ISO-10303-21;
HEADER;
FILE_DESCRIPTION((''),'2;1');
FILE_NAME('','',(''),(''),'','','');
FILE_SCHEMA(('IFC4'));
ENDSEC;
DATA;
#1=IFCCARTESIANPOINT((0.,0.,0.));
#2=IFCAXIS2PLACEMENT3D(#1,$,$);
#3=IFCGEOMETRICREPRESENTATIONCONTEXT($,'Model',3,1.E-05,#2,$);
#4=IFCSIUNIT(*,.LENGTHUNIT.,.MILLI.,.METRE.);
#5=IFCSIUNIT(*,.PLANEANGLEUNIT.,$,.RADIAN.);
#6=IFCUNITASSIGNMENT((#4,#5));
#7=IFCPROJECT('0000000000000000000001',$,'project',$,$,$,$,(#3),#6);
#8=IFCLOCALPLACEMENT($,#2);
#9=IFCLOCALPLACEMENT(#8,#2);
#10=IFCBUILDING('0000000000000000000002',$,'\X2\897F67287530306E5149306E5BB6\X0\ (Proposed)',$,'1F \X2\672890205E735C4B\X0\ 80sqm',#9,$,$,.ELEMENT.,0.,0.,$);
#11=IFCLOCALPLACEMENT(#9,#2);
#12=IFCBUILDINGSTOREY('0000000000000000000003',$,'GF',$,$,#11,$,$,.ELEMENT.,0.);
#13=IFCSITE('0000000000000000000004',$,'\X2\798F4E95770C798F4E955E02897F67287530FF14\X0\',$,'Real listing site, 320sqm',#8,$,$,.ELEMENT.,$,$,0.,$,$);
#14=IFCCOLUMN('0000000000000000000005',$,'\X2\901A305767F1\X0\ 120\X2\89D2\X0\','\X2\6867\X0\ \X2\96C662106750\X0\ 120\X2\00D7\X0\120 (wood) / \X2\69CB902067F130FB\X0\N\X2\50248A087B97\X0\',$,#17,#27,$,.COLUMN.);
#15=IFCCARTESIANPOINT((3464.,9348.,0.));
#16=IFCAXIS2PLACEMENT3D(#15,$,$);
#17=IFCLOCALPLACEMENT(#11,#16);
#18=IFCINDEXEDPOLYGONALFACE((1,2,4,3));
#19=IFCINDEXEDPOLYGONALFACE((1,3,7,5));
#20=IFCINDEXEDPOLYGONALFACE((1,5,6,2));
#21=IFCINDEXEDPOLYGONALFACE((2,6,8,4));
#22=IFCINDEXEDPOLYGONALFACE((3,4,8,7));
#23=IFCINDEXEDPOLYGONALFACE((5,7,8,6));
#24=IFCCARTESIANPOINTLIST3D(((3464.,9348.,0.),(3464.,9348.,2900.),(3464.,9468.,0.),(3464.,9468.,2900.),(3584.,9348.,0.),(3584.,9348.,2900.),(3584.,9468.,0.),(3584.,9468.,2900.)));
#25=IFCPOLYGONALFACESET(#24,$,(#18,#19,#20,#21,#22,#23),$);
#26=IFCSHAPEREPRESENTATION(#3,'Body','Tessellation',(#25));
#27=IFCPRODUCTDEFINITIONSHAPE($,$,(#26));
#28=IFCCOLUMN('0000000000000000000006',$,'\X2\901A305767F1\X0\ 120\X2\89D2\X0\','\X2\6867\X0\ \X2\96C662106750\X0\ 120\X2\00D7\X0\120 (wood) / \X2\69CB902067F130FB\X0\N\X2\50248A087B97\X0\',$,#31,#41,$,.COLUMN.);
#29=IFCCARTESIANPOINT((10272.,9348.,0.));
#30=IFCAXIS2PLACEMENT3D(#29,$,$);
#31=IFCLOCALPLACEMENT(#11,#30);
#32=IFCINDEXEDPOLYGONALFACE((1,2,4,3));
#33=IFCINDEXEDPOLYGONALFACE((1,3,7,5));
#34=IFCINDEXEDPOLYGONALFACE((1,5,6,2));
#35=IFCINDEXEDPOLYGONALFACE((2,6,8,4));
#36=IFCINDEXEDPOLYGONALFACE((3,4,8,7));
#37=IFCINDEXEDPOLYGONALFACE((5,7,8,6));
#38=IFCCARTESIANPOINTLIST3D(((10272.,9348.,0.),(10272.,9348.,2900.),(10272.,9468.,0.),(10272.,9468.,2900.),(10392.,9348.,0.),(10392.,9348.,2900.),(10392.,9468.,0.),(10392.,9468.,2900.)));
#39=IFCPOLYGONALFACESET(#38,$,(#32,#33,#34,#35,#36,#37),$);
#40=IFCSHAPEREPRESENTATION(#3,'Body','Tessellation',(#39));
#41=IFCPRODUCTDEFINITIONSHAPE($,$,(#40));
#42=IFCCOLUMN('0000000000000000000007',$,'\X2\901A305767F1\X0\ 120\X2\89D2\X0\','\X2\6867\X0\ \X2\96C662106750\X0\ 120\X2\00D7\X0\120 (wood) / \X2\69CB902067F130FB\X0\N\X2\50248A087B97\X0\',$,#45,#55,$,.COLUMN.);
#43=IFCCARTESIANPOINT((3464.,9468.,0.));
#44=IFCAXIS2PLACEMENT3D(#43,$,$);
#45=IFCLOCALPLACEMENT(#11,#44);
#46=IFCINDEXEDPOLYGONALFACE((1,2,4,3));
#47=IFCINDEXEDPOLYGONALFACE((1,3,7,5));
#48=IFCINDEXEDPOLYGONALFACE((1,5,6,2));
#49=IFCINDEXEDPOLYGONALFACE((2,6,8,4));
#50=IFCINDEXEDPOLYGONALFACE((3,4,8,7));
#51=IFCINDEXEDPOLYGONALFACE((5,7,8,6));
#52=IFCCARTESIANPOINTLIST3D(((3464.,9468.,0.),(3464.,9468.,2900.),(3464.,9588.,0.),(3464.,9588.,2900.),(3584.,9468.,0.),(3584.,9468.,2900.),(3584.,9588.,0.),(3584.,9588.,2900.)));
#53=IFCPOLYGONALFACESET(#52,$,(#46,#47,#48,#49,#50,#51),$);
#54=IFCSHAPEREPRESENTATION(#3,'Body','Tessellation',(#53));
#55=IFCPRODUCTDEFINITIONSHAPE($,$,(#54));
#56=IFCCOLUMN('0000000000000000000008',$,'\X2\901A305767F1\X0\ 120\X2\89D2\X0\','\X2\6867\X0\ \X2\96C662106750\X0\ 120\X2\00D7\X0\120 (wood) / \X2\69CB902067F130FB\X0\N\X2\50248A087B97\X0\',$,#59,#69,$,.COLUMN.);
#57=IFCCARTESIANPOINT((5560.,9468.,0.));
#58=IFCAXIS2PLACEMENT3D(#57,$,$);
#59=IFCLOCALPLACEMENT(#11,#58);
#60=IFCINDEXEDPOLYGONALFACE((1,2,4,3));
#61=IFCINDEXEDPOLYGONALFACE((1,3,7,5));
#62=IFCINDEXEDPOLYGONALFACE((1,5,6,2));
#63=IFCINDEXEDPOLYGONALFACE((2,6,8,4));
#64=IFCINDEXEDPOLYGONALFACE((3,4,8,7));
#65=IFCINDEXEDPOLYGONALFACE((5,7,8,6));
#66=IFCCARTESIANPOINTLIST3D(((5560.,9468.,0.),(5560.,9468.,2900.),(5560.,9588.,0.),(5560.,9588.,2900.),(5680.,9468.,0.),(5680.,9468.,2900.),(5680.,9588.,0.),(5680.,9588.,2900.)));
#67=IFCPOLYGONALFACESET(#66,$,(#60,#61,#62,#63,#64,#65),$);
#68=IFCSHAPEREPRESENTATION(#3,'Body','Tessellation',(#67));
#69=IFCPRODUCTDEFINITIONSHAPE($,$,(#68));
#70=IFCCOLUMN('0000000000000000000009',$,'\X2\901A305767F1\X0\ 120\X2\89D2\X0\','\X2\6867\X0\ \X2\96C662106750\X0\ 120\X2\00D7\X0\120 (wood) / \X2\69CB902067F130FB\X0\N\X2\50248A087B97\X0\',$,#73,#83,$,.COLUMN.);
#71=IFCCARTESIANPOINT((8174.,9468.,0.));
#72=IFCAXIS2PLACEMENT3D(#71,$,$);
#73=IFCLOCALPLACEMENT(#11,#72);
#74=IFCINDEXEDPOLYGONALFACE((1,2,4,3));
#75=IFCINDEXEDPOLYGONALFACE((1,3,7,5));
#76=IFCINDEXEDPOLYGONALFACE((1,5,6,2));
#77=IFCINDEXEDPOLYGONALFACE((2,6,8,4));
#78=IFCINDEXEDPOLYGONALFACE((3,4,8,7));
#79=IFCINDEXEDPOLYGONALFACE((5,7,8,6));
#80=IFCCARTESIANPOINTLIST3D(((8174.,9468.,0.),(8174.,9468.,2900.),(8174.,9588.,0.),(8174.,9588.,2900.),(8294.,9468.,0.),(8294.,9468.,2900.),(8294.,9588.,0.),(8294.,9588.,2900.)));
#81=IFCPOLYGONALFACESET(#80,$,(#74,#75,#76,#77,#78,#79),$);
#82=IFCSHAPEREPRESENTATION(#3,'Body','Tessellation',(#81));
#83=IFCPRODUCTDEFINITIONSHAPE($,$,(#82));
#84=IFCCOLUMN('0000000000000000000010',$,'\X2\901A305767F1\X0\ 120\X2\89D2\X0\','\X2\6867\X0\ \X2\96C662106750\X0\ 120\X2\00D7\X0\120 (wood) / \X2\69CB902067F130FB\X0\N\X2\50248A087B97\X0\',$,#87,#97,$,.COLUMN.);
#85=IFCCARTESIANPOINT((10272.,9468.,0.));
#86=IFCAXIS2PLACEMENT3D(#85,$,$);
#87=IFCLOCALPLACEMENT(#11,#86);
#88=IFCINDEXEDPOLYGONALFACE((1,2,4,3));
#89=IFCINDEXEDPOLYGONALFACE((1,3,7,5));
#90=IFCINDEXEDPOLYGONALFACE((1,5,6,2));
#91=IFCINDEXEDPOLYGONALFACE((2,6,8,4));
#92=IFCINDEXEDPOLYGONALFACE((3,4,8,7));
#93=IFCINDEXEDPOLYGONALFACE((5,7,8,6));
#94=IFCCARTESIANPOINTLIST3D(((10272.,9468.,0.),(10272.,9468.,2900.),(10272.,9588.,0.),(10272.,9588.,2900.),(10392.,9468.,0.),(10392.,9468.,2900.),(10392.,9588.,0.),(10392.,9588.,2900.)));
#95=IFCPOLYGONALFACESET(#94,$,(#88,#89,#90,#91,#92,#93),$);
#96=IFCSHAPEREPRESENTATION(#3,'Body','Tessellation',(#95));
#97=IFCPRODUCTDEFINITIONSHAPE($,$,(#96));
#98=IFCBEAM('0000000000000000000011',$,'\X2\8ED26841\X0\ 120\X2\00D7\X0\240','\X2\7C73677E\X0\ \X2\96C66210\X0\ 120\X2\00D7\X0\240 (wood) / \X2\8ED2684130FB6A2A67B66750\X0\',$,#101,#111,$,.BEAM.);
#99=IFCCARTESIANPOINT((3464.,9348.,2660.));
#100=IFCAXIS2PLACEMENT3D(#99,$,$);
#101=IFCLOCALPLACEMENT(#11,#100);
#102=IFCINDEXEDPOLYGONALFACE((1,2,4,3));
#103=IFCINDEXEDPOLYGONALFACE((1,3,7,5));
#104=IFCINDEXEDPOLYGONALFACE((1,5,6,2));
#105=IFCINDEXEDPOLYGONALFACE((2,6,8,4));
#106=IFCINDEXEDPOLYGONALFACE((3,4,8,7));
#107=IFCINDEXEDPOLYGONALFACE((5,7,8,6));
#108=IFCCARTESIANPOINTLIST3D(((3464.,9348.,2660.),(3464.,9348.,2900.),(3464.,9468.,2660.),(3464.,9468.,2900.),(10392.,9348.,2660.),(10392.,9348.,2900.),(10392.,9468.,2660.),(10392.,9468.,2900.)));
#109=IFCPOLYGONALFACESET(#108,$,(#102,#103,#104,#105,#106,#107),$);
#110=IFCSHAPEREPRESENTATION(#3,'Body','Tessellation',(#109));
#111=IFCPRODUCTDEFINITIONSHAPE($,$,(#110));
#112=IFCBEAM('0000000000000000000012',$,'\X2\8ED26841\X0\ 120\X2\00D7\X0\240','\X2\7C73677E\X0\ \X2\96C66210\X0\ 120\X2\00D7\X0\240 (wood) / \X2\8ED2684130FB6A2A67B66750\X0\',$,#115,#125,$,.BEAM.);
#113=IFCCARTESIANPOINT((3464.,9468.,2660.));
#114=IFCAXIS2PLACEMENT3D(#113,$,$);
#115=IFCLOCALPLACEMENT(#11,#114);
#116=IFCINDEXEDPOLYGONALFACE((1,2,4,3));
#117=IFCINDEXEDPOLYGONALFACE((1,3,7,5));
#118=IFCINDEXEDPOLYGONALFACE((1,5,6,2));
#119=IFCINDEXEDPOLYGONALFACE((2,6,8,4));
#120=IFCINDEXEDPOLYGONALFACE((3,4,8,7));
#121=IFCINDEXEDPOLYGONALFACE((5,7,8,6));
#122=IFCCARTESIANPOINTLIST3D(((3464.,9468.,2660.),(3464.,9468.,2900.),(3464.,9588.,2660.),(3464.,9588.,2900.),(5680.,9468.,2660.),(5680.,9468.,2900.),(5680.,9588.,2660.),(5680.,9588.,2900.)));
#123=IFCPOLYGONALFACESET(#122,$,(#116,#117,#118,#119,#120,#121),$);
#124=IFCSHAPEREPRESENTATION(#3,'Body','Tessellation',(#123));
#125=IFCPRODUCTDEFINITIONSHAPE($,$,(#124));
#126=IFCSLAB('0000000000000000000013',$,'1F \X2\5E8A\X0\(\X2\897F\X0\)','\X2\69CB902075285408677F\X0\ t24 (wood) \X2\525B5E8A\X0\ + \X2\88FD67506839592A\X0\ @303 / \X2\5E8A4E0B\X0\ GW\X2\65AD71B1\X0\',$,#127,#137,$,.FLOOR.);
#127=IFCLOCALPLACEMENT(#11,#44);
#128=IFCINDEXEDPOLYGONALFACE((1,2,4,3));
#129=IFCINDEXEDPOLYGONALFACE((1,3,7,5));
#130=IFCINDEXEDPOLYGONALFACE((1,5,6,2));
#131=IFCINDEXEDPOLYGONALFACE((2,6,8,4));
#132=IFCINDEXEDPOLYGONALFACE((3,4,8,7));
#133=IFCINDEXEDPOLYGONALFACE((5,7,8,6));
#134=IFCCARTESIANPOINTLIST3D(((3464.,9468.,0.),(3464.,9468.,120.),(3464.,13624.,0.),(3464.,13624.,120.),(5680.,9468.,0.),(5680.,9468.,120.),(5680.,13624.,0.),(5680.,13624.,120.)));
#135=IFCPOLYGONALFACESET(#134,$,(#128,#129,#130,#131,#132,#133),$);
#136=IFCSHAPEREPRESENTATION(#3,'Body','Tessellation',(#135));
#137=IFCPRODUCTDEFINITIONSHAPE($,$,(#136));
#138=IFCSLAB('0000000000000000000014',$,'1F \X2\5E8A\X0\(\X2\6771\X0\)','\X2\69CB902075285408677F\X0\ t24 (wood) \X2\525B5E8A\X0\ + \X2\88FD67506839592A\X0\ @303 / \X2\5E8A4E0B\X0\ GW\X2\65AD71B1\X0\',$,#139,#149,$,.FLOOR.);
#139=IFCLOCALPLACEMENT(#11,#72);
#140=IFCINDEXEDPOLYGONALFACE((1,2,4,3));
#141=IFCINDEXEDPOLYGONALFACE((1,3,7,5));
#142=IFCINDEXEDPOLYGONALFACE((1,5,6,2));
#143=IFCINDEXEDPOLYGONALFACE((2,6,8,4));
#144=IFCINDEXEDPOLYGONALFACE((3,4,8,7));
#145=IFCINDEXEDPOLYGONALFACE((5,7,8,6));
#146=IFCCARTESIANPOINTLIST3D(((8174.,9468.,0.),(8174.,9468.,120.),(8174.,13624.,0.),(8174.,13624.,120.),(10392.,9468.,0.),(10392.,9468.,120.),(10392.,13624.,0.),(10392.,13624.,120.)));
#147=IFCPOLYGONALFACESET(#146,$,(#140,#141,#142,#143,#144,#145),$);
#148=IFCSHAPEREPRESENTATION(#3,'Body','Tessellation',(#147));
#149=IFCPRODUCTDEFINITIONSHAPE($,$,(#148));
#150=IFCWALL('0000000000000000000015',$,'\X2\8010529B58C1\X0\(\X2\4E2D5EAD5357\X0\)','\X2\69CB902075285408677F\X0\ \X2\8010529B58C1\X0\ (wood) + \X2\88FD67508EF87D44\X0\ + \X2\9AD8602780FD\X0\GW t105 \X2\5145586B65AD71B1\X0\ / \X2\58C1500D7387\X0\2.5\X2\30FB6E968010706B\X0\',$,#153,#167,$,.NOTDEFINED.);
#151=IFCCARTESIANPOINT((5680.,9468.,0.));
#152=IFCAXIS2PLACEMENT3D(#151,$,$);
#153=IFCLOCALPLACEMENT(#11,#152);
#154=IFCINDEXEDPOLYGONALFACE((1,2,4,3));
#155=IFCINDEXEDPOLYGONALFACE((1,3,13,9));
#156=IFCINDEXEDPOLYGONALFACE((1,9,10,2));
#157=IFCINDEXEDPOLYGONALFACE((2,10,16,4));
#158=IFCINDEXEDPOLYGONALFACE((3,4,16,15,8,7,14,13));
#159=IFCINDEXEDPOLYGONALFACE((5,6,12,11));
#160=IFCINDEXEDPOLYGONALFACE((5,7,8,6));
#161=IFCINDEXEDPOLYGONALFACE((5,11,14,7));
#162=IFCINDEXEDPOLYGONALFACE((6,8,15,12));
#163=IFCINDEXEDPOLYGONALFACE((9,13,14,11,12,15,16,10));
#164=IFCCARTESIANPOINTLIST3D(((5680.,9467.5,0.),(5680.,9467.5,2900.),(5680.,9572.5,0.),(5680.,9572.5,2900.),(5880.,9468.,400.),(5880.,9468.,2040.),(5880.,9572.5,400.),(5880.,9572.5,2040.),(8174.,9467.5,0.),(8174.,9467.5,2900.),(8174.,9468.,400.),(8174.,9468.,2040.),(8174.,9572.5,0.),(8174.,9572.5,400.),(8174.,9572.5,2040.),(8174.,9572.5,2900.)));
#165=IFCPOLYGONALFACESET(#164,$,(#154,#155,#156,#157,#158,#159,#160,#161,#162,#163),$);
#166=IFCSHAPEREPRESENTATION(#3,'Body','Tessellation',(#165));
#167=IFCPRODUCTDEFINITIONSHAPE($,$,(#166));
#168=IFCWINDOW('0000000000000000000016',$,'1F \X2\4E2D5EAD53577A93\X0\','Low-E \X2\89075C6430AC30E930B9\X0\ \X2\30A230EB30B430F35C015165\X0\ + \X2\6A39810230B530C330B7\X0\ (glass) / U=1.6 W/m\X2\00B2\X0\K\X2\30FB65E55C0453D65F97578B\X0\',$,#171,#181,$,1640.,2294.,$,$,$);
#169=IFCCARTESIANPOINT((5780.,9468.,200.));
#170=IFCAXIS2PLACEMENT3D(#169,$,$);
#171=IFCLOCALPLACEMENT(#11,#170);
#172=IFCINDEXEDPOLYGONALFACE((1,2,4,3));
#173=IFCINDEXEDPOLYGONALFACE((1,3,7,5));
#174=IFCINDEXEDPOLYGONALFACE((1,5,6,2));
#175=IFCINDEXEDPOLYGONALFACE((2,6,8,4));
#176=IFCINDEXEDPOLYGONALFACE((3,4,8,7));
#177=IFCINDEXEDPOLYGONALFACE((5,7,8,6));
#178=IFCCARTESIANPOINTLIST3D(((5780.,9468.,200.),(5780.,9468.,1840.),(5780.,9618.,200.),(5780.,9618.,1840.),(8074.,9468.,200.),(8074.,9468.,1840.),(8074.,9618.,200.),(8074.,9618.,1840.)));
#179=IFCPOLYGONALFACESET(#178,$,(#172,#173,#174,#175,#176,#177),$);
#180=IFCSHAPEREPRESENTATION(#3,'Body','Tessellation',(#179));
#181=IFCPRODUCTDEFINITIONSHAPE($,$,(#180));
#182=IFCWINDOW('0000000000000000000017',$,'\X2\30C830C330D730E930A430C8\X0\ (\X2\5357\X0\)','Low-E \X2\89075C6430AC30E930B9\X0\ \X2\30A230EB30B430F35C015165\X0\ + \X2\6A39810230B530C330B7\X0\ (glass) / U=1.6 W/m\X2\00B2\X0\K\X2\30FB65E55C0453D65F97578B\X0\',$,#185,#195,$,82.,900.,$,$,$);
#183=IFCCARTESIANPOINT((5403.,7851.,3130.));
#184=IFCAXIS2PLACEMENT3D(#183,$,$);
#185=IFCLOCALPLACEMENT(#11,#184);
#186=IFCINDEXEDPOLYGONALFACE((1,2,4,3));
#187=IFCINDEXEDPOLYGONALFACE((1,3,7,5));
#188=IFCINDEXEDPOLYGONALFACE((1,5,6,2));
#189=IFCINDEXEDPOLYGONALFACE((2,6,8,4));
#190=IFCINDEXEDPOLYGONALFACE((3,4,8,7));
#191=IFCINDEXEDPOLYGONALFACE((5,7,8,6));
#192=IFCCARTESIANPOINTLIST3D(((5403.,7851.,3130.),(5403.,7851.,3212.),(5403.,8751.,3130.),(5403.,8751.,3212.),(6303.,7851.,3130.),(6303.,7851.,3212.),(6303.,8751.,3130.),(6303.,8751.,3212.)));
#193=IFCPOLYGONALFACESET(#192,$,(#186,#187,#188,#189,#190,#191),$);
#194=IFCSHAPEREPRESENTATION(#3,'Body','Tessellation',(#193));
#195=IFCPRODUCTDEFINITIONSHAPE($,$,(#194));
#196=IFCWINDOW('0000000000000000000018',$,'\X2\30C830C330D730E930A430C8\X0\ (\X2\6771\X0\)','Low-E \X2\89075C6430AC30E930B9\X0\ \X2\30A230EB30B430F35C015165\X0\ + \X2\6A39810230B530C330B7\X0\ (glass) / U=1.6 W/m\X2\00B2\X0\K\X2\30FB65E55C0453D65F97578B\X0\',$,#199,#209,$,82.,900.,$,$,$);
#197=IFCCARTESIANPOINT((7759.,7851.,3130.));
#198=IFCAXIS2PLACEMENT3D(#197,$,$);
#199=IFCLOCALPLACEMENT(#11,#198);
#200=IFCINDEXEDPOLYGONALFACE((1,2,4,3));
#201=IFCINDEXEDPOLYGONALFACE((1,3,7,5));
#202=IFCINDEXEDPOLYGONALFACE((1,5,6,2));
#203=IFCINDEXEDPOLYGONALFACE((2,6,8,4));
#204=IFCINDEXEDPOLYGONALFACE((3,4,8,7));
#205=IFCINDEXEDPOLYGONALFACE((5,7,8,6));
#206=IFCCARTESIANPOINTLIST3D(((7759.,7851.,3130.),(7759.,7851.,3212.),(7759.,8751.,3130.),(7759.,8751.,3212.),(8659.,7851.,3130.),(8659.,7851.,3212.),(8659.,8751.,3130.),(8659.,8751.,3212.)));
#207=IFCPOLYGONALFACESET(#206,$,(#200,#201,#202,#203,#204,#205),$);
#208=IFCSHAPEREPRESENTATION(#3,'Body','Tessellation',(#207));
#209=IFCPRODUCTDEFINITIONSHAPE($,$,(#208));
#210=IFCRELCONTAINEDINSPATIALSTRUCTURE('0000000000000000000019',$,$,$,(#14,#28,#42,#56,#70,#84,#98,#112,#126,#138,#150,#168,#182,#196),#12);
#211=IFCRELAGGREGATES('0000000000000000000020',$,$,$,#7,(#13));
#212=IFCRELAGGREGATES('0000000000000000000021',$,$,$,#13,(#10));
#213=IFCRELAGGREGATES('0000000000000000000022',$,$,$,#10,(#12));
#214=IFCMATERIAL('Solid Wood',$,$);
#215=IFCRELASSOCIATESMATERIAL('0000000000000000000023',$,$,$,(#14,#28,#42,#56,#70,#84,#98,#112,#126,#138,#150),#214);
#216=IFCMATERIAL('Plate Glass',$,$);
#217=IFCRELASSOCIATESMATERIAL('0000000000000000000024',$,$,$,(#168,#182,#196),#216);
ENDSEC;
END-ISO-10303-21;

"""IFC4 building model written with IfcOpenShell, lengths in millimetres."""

from ifc_helpers import new_model, si_unit, frame, frame_2d, origin, place, context, project, spatial, rectangle, extrude, material, element, fill, save


model = new_model("IFC4")

# Units and contexts
model_context = context("Model", 3, precision=1e-05, world=origin())
ifc_project = project(units=[si_unit("LENGTHUNIT", "METRE", prefix="MILLI"), si_unit("PLANEANGLEUNIT", "RADIAN")], contexts=[model_context])

# Site, building, storey
site_placement = place(None, origin())
site = spatial("IfcSite", under=ifc_project, at=site_placement, Name="福井県福井市西木田４", ObjectType="Real listing site, 320sqm", CompositionType="ELEMENT", RefElevation=0.0)
building_placement = place(site_placement, origin())
building = spatial("IfcBuilding", under=site, at=building_placement, Name="西木田の光の家 (Proposed)", ObjectType="1F 木造平屋 80sqm", CompositionType="ELEMENT", ElevationOfRefHeight=0.0, ElevationOfTerrain=0.0)
storey_placement = place(building_placement, origin())
storey = spatial("IfcBuildingStorey", under=building, at=storey_placement, Name="GF", CompositionType="ELEMENT", Elevation=0.0)

# Columns
ifc_material_1 = material(Name="Solid Wood")
column_1_placement = place(storey_placement, frame((3464.0, 9348.0, 0.0)))
element("IfcColumn", 1, at=column_1_placement, inside=storey, material=ifc_material_1, Name="通し柱 120角", Description="桧 集成材 120×120 (wood) / 構造柱・N値計算", PredefinedType="COLUMN", context=model_context, shape_type="SweptSolid", body=[
    extrude(rectangle(XDim=120.0, YDim=120.0, at=frame_2d((60.0, 60.0))), frame((3464.0, 9348.0, 0.0)), (0.0, 0.0, 1.0), 2900.0),
])
column_2_placement = place(storey_placement, frame((10272.0, 9348.0, 0.0)))
element("IfcColumn", 2, at=column_2_placement, inside=storey, material=ifc_material_1, Name="通し柱 120角", Description="桧 集成材 120×120 (wood) / 構造柱・N値計算", PredefinedType="COLUMN", context=model_context, shape_type="SweptSolid", body=[
    extrude(rectangle(XDim=120.0, YDim=120.0, at=frame_2d((60.0, 60.0))), frame((10272.0, 9348.0, 0.0)), (0.0, 0.0, 1.0), 2900.0),
])
column_3_placement = place(storey_placement, frame((3464.0, 9468.0, 0.0)))
element("IfcColumn", 3, at=column_3_placement, inside=storey, material=ifc_material_1, Name="通し柱 120角", Description="桧 集成材 120×120 (wood) / 構造柱・N値計算", PredefinedType="COLUMN", context=model_context, shape_type="SweptSolid", body=[
    extrude(rectangle(XDim=120.0, YDim=120.0, at=frame_2d((60.0, 60.0))), frame((3464.0, 9468.0, 0.0)), (0.0, 0.0, 1.0), 2900.0),
])
column_4_placement = place(storey_placement, frame((5560.0, 9468.0, 0.0)))
element("IfcColumn", 4, at=column_4_placement, inside=storey, material=ifc_material_1, Name="通し柱 120角", Description="桧 集成材 120×120 (wood) / 構造柱・N値計算", PredefinedType="COLUMN", context=model_context, shape_type="SweptSolid", body=[
    extrude(rectangle(XDim=120.0, YDim=120.0, at=frame_2d((60.0, 60.0))), frame((5560.0, 9468.0, 0.0)), (0.0, 0.0, 1.0), 2900.0),
])
column_5_placement = place(storey_placement, frame((8174.0, 9468.0, 0.0)))
element("IfcColumn", 5, at=column_5_placement, inside=storey, material=ifc_material_1, Name="通し柱 120角", Description="桧 集成材 120×120 (wood) / 構造柱・N値計算", PredefinedType="COLUMN", context=model_context, shape_type="SweptSolid", body=[
    extrude(rectangle(XDim=120.0, YDim=120.0, at=frame_2d((60.0, 60.0))), frame((8174.0, 9468.0, 0.0)), (0.0, 0.0, 1.0), 2900.0),
])
column_6_placement = place(storey_placement, frame((10272.0, 9468.0, 0.0)))
element("IfcColumn", 6, at=column_6_placement, inside=storey, material=ifc_material_1, Name="通し柱 120角", Description="桧 集成材 120×120 (wood) / 構造柱・N値計算", PredefinedType="COLUMN", context=model_context, shape_type="SweptSolid", body=[
    extrude(rectangle(XDim=120.0, YDim=120.0, at=frame_2d((60.0, 60.0))), frame((10272.0, 9468.0, 0.0)), (0.0, 0.0, 1.0), 2900.0),
])

# Beams
beam_1_placement = place(storey_placement, frame((3464.0, 9348.0, 2660.0)))
element("IfcBeam", 7, at=beam_1_placement, inside=storey, material=ifc_material_1, Name="軒桁 120×240", Description="米松 集成 120×240 (wood) / 軒桁・横架材", PredefinedType="BEAM", context=model_context, shape_type="SweptSolid", body=[
    extrude(rectangle(XDim=6928.0, YDim=120.0, at=frame_2d((3464.0, 60.0))), frame((3464.0, 9348.0, 2660.0)), (0.0, 0.0, 1.0), 240.0),
])
beam_2_placement = place(storey_placement, frame((3464.0, 9468.0, 2660.0)))
element("IfcBeam", 8, at=beam_2_placement, inside=storey, material=ifc_material_1, Name="軒桁 120×240", Description="米松 集成 120×240 (wood) / 軒桁・横架材", PredefinedType="BEAM", context=model_context, shape_type="SweptSolid", body=[
    extrude(rectangle(XDim=2216.0, YDim=120.0, at=frame_2d((1108.0, 60.0))), frame((3464.0, 9468.0, 2660.0)), (0.0, 0.0, 1.0), 240.0),
])

# Slabs
slab_1_placement = place(storey_placement, frame((3464.0, 9468.0, 0.0)))
element("IfcSlab", 9, at=slab_1_placement, inside=storey, material=ifc_material_1, Name="1F 床(西)", Description="構造用合板 t24 (wood) 剛床 + 製材根太 @303 / 床下 GW断熱", PredefinedType="FLOOR", context=model_context, shape_type="SweptSolid", body=[
    extrude(rectangle(XDim=2216.0, YDim=4156.0, at=frame_2d((1108.0, 2078.0))), frame((3464.0, 9468.0, 0.0)), (0.0, 0.0, 1.0), 120.0),
])
slab_2_placement = place(storey_placement, frame((8174.0, 9468.0, 0.0)))
element("IfcSlab", 10, at=slab_2_placement, inside=storey, material=ifc_material_1, Name="1F 床(東)", Description="構造用合板 t24 (wood) 剛床 + 製材根太 @303 / 床下 GW断熱", PredefinedType="FLOOR", context=model_context, shape_type="SweptSolid", body=[
    extrude(rectangle(XDim=2218.0, YDim=4156.0, at=frame_2d((1109.0, 2078.0))), frame((8174.0, 9468.0, 0.0)), (0.0, 0.0, 1.0), 120.0),
])

# Wall, opening, window
wall_1_placement = place(storey_placement, frame((5680.0, 9468.0, 0.0)))
wall_1 = element("IfcWall", 11, at=wall_1_placement, inside=storey, material=ifc_material_1, Name="耐力壁(中庭南)", Description="構造用合板 耐力壁 (wood) + 製材軸組 + 高性能GW t105 充填断熱 / 壁倍率2.5・準耐火", PredefinedType="NOTDEFINED", context=model_context, shape_type="SweptSolid", body=[
    extrude(rectangle(XDim=2494.0, YDim=105.0, at=frame_2d((1247.0, 52.0))), frame((5680.0, 9468.0, 0.0)), (0.0, 0.0, 1.0), 2900.0),
])
opening_placement = place(storey_placement, frame((5780.0, 9468.0, 200.0)))
opening = element("IfcOpeningElement", 12, at=opening_placement, cuts=wall_1, PredefinedType="NOTDEFINED", context=model_context, shape_type="SweptSolid", body=[
    extrude(rectangle(XDim=2294.0, YDim=150.0, at=frame_2d((1147.0, 75.0))), frame((5780.0, 9468.0, 200.0)), (0.0, 0.0, 1.0), 1640.0),
])
ifc_material_2 = material(Name="Plate Glass")
window_1_placement = place(storey_placement, frame((5780.0, 9468.0, 200.0)))
window_1 = element("IfcWindow", 13, at=window_1_placement, inside=storey, material=ifc_material_2, Name="1F 中庭南窓", Description="Low-E 複層ガラス アルゴン封入 + 樹脂サッシ (glass) / U=1.6 W/m²K・日射取得型", OverallHeight=1640.0, OverallWidth=2294.0, context=model_context, shape_type="SweptSolid", body=[
    extrude(rectangle(XDim=2294.0, YDim=150.0, at=frame_2d((1147.0, 75.0))), frame((5780.0, 9468.0, 200.0)), (0.0, 0.0, 1.0), 1640.0),
])
fill(opening, window_1)

# Windows
window_2_placement = place(storey_placement, frame((5403.0, 7851.0, 3130.0)))
element("IfcWindow", 14, at=window_2_placement, inside=storey, material=ifc_material_2, Name="トップライト (南)", Description="Low-E 複層ガラス アルゴン封入 + 樹脂サッシ (glass) / U=1.6 W/m²K・日射取得型", OverallHeight=82.0, OverallWidth=900.0, context=model_context, shape_type="SweptSolid", body=[
    extrude(rectangle(XDim=900.0, YDim=900.0, at=frame_2d((450.0, 450.0))), frame((5403.0, 7851.0, 3130.0)), (0.0, 0.0, 1.0), 82.0),
])
window_3_placement = place(storey_placement, frame((7759.0, 7851.0, 3130.0)))
element("IfcWindow", 15, at=window_3_placement, inside=storey, material=ifc_material_2, Name="トップライト (東)", Description="Low-E 複層ガラス アルゴン封入 + 樹脂サッシ (glass) / U=1.6 W/m²K・日射取得型", OverallHeight=82.0, OverallWidth=900.0, context=model_context, shape_type="SweptSolid", body=[
    extrude(rectangle(XDim=900.0, YDim=900.0, at=frame_2d((450.0, 450.0))), frame((7759.0, 7851.0, 3130.0)), (0.0, 0.0, 1.0), 82.0),
])

save(model, "model.ifc")
